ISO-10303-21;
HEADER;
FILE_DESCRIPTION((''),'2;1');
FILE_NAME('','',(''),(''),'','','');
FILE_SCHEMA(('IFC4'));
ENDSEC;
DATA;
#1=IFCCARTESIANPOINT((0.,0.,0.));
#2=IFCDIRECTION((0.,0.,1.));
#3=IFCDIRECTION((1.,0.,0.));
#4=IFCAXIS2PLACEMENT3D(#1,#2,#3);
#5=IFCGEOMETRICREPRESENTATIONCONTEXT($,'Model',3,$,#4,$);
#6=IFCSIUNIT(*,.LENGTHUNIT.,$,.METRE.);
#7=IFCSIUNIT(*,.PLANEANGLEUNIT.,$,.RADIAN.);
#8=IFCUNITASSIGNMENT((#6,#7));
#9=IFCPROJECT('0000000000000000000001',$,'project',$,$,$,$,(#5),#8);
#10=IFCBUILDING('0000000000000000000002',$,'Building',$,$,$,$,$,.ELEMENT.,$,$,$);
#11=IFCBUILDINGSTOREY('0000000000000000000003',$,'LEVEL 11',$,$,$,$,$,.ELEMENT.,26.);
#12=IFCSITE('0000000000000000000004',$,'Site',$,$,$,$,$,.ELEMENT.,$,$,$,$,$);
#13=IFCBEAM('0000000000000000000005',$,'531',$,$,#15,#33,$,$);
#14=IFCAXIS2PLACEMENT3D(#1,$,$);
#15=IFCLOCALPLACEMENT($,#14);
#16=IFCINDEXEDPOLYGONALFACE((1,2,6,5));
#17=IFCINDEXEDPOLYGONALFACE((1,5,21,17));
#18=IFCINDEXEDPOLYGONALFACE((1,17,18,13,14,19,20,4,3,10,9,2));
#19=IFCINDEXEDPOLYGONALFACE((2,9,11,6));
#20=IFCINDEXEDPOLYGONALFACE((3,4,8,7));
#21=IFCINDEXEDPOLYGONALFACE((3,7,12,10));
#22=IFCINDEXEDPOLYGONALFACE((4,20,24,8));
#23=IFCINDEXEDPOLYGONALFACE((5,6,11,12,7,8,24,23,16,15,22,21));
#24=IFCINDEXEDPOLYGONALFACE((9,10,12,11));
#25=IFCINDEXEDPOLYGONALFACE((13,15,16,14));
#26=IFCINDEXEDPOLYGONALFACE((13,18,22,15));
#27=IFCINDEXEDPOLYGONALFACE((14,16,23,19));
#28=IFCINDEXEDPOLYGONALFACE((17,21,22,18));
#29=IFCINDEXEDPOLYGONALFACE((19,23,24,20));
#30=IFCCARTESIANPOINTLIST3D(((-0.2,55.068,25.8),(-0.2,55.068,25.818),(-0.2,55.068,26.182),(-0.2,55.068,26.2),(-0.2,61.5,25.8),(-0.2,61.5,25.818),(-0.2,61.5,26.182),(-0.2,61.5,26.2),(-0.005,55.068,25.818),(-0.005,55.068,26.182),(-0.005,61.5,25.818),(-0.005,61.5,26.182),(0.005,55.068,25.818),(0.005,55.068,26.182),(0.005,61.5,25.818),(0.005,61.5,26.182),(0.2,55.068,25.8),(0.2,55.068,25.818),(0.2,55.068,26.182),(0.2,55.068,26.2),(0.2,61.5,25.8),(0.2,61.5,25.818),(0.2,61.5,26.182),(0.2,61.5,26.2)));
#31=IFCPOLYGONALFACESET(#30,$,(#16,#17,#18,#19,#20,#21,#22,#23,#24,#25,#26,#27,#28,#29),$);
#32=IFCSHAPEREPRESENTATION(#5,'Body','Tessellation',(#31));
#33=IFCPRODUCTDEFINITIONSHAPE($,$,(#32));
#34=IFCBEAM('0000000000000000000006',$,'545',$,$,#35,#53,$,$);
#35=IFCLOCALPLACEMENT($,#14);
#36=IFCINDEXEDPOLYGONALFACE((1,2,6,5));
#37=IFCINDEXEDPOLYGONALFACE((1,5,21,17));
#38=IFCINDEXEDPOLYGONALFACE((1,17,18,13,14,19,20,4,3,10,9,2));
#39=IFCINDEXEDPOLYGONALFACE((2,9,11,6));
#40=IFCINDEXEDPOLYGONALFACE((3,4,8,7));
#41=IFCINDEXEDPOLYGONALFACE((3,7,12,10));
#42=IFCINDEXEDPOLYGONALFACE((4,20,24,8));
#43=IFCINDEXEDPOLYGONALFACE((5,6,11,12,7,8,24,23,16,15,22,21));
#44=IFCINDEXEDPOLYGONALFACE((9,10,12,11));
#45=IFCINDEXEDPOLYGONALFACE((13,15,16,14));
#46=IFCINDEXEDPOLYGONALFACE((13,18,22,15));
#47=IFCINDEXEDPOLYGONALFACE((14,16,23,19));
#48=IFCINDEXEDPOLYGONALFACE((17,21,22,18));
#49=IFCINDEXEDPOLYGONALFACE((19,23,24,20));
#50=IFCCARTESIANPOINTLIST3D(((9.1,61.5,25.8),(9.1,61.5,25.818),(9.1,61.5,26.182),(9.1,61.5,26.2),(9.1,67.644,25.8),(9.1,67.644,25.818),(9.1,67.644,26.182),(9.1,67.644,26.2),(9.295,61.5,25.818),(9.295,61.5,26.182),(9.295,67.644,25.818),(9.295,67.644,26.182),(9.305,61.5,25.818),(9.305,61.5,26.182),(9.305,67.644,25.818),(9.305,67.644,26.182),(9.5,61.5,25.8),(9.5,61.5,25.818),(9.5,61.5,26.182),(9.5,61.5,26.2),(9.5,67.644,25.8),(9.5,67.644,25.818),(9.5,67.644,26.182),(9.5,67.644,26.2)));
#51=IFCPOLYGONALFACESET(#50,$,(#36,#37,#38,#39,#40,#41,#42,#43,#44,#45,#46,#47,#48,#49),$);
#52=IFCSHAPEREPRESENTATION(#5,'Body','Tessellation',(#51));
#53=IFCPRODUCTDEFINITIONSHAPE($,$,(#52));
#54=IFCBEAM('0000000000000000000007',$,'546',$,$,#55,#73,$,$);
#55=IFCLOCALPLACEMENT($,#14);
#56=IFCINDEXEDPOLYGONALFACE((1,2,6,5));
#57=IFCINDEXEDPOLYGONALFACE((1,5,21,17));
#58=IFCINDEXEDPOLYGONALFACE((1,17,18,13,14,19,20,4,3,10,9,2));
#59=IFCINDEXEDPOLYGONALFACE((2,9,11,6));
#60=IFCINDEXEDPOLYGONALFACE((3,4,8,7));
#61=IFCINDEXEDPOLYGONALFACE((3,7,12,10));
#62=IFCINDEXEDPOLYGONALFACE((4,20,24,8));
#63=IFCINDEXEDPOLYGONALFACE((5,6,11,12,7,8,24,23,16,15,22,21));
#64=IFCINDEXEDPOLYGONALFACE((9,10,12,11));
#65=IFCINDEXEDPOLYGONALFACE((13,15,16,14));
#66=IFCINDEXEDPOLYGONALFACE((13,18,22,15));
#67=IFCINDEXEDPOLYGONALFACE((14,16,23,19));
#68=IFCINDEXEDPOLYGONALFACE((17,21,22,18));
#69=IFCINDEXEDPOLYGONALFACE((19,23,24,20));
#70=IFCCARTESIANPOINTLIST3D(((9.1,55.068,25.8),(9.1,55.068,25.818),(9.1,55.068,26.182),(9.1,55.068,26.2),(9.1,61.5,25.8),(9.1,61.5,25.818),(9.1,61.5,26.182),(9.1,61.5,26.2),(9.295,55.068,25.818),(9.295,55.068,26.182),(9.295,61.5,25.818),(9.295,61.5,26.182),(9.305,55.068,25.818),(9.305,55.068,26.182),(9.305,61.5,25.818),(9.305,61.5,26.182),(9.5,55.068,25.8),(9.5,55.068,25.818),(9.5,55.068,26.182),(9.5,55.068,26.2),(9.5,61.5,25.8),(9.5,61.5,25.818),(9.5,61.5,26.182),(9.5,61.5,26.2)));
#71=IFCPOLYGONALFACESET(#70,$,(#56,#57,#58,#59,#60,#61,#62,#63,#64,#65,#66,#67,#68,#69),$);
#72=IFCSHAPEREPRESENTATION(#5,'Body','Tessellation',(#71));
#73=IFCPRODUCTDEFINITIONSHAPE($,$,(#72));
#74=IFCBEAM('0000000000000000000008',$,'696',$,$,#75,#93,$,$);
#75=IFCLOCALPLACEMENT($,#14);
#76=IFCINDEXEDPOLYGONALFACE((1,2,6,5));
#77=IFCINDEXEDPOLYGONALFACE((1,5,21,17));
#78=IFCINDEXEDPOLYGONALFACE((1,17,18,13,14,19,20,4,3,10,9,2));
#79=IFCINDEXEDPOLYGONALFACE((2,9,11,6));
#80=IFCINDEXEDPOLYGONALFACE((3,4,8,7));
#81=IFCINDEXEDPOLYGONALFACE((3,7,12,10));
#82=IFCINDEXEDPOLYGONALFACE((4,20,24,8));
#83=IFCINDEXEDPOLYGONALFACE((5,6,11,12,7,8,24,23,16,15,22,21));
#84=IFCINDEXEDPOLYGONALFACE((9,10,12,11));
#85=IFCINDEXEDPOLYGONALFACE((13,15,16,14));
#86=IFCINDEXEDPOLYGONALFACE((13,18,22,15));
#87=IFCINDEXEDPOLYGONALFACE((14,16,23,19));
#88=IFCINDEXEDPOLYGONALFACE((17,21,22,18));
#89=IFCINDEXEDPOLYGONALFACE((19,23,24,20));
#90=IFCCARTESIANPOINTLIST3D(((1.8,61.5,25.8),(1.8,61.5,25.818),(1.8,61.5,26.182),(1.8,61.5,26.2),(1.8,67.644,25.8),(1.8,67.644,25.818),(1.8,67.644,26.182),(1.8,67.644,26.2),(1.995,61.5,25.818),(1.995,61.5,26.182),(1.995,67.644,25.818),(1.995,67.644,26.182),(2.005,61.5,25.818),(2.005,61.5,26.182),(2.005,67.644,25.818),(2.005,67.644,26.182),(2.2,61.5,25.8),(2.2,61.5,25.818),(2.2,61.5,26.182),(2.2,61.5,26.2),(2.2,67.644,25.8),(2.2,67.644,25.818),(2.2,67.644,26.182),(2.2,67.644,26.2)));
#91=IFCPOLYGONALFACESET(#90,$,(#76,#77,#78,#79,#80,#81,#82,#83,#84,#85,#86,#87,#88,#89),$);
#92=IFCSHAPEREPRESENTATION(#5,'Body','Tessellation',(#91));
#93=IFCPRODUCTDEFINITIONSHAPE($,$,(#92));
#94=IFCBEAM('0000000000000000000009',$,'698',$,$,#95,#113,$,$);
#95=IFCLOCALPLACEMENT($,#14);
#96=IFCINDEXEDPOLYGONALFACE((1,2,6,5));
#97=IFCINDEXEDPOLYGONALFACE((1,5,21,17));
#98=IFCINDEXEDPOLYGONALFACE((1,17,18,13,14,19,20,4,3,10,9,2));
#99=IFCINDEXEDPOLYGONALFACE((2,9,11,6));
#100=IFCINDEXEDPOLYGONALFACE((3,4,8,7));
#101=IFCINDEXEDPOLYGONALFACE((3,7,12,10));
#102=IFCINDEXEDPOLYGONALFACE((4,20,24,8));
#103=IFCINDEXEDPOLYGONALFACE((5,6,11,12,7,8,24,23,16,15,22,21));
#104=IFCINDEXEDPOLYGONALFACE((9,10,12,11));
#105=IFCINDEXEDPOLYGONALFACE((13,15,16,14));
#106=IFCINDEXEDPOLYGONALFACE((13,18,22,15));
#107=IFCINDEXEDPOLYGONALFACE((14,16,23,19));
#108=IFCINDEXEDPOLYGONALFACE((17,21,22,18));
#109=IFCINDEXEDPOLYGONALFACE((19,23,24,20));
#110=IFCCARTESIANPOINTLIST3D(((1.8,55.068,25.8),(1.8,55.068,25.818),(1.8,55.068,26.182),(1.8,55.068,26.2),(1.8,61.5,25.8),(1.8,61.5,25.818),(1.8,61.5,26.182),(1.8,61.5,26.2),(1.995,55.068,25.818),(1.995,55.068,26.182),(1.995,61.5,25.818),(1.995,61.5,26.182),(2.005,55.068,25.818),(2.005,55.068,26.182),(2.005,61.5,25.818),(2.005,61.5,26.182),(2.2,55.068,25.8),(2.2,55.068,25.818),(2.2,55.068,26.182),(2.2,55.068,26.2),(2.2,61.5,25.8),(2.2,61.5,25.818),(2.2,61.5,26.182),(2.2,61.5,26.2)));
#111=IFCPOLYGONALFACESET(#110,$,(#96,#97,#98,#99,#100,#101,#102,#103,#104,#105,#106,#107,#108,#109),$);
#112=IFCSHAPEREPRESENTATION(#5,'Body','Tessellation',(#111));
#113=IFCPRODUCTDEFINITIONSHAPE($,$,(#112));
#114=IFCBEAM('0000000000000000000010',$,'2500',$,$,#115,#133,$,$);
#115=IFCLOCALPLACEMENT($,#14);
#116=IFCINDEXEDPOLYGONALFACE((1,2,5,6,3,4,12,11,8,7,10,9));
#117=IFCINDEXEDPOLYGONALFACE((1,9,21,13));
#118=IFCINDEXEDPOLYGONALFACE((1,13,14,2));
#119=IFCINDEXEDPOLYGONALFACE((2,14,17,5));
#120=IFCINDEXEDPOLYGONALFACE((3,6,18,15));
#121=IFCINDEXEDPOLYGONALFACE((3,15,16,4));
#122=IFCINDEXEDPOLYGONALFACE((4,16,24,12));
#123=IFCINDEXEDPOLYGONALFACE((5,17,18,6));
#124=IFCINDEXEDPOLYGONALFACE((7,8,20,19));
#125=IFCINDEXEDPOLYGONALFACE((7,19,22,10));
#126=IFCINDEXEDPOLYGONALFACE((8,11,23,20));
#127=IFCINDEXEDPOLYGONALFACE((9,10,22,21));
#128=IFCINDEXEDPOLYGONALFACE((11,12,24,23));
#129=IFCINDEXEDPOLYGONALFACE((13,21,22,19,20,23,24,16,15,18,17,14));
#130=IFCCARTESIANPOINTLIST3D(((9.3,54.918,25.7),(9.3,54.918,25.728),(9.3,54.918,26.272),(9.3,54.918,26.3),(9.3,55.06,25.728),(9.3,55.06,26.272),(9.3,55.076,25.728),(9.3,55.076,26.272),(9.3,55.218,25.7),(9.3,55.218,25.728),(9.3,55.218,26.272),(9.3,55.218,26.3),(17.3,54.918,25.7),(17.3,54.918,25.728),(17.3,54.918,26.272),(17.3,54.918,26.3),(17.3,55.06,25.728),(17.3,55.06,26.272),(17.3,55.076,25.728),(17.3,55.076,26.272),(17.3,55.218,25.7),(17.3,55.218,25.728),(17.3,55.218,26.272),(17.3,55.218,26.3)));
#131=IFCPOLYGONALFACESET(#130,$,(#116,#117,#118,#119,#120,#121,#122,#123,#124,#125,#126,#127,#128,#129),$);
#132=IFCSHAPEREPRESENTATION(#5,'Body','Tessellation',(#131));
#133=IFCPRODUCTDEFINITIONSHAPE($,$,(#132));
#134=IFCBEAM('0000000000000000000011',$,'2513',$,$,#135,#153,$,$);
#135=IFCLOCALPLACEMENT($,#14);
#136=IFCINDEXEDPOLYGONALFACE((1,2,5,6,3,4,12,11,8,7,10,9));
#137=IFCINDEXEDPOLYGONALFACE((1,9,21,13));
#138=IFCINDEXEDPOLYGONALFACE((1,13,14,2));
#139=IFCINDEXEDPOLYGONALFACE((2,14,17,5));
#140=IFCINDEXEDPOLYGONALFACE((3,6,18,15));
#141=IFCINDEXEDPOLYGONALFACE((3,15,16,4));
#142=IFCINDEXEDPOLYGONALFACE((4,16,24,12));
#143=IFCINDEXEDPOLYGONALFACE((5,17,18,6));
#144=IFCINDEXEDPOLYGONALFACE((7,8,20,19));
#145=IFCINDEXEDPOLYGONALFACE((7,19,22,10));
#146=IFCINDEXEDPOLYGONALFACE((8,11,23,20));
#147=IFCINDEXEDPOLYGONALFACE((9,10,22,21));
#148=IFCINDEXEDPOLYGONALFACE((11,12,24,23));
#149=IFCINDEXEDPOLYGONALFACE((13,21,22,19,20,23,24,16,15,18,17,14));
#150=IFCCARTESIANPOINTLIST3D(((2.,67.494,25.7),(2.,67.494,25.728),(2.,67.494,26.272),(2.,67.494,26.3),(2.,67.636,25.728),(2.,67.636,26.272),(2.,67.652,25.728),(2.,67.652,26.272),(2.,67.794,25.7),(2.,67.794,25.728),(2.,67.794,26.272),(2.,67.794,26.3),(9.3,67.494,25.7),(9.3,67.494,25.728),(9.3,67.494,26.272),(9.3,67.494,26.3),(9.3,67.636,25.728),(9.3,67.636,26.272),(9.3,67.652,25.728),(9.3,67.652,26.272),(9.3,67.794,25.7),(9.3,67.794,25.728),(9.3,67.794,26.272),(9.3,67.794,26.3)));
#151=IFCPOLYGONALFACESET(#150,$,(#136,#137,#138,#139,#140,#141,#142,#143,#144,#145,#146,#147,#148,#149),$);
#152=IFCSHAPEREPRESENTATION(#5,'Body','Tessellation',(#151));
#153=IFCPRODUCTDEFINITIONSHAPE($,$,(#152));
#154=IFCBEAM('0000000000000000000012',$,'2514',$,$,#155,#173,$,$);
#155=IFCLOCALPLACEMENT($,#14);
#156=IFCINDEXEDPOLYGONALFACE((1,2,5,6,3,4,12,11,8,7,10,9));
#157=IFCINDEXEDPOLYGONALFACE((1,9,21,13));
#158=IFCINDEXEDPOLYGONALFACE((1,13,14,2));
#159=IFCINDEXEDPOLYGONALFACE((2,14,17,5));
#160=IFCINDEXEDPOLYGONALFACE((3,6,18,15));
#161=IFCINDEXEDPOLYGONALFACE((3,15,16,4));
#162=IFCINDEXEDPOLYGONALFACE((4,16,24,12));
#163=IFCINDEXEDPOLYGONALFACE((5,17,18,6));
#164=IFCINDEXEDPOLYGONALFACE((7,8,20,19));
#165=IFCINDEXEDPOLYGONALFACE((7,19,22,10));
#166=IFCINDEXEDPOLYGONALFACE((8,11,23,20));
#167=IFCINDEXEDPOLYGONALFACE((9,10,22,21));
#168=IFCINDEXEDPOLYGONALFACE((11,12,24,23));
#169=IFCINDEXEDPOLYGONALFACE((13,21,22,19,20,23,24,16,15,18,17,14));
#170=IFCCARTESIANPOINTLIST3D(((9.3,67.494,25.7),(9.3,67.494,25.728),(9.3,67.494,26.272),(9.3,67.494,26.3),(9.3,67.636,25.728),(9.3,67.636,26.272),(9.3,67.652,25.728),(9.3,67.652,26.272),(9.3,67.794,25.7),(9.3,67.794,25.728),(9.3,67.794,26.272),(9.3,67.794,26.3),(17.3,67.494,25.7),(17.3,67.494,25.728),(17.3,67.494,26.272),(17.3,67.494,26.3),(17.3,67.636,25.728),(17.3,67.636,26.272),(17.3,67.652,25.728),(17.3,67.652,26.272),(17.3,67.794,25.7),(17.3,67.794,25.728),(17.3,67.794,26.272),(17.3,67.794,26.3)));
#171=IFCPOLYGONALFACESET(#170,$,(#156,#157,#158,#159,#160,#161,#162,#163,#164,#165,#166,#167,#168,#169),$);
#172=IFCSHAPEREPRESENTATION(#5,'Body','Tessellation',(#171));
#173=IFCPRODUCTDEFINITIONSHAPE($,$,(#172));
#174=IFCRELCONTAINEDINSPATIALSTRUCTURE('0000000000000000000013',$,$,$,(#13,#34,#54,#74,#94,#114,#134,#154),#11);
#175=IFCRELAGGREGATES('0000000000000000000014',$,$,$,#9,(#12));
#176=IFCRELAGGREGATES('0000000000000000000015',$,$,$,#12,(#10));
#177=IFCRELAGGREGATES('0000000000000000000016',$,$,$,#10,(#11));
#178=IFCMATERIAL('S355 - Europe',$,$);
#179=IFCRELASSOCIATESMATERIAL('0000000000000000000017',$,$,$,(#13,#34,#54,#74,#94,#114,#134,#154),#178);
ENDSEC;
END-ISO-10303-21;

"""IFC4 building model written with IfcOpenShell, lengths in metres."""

from ifc_helpers import new_model, si_unit, frame, origin_with_axes, origin_2d_with_axis, place, context, project, spatial, i_section, extrude, material, material_profile, profile_set, profile_usage, element, save


model = new_model("IFC4")

# Units and contexts
model_context = context("Model", 3, world=origin_with_axes())
ifc_project = project(units=[si_unit("LENGTHUNIT", "METRE"), si_unit("PLANEANGLEUNIT", "RADIAN")], contexts=[model_context])

# Site, building, storey
site = spatial("IfcSite", under=ifc_project, Name="Site", CompositionType="ELEMENT")
building = spatial("IfcBuilding", under=site, Name="Building", CompositionType="ELEMENT")
storey = spatial("IfcBuildingStorey", under=building, Name="LEVEL 11", CompositionType="ELEMENT", Elevation=26.0)

# Shared definitions
ifc_material = material(Name="S355 - Europe")

# Beams
ifc_material_profile_1 = material_profile(ifc_material, i_section(OverallWidth=0.4, OverallDepth=0.4, WebThickness=0.01, FlangeThickness=0.018, at=origin_2d_with_axis()))
ifc_profile_set_1 = profile_set([ifc_material_profile_1])
ifc_profile_usage_1 = profile_usage(ifc_profile_set_1, cardinal=10)
beam_1_placement = place(None, frame((0.0, 61.5, 26.0), z_axis=(0.0, -1.0, 0.0), x_axis=(1.0, 0.0, 0.0)))
element("IfcBeam", 1, at=beam_1_placement, inside=storey, material=ifc_profile_usage_1, Name="531", context=model_context, shape_type="SweptSolid", body=[
    extrude(i_section(OverallWidth=0.4, OverallDepth=0.4, WebThickness=0.01, FlangeThickness=0.018, at=origin_2d_with_axis()), origin_with_axes(), (0.0, 0.0, 1.0), 6.432),
])
ifc_material_profile_2 = material_profile(ifc_material, i_section(OverallWidth=0.4, OverallDepth=0.4, WebThickness=0.01, FlangeThickness=0.018, at=origin_2d_with_axis()))
ifc_profile_set_2 = profile_set([ifc_material_profile_2])
ifc_profile_usage_2 = profile_usage(ifc_profile_set_2, cardinal=10)
beam_2_placement = place(None, frame((9.3, 67.644, 26.0), z_axis=(0.0, -1.0, 0.0), x_axis=(1.0, 0.0, 0.0)))
element("IfcBeam", 2, at=beam_2_placement, inside=storey, material=ifc_profile_usage_2, Name="545", context=model_context, shape_type="SweptSolid", body=[
    extrude(i_section(OverallWidth=0.4, OverallDepth=0.4, WebThickness=0.01, FlangeThickness=0.018, at=origin_2d_with_axis()), origin_with_axes(), (0.0, 0.0, 1.0), 6.144),
])
ifc_material_profile_3 = material_profile(ifc_material, i_section(OverallWidth=0.4, OverallDepth=0.4, WebThickness=0.01, FlangeThickness=0.018, at=origin_2d_with_axis()))
ifc_profile_set_3 = profile_set([ifc_material_profile_3])
ifc_profile_usage_3 = profile_usage(ifc_profile_set_3, cardinal=10)
beam_3_placement = place(None, frame((9.3, 61.5, 26.0), z_axis=(0.0, -1.0, 0.0), x_axis=(1.0, 0.0, 0.0)))
element("IfcBeam", 3, at=beam_3_placement, inside=storey, material=ifc_profile_usage_3, Name="546", context=model_context, shape_type="SweptSolid", body=[
    extrude(i_section(OverallWidth=0.4, OverallDepth=0.4, WebThickness=0.01, FlangeThickness=0.018, at=origin_2d_with_axis()), origin_with_axes(), (0.0, 0.0, 1.0), 6.432),
])
ifc_material_profile_4 = material_profile(ifc_material, i_section(OverallWidth=0.4, OverallDepth=0.4, WebThickness=0.01, FlangeThickness=0.018, at=origin_2d_with_axis()))
ifc_profile_set_4 = profile_set([ifc_material_profile_4])
ifc_profile_usage_4 = profile_usage(ifc_profile_set_4, cardinal=10)
beam_4_placement = place(None, frame((2.0, 67.644, 26.0), z_axis=(0.0, -1.0, 0.0), x_axis=(1.0, 0.0, 0.0)))
element("IfcBeam", 4, at=beam_4_placement, inside=storey, material=ifc_profile_usage_4, Name="696", context=model_context, shape_type="SweptSolid", body=[
    extrude(i_section(OverallWidth=0.4, OverallDepth=0.4, WebThickness=0.01, FlangeThickness=0.018, at=origin_2d_with_axis()), origin_with_axes(), (0.0, 0.0, 1.0), 6.144),
])
ifc_material_profile_5 = material_profile(ifc_material, i_section(OverallWidth=0.4, OverallDepth=0.4, WebThickness=0.01, FlangeThickness=0.018, at=origin_2d_with_axis()))
ifc_profile_set_5 = profile_set([ifc_material_profile_5])
ifc_profile_usage_5 = profile_usage(ifc_profile_set_5, cardinal=10)
beam_5_placement = place(None, frame((2.0, 61.5, 26.0), z_axis=(0.0, -1.0, 0.0), x_axis=(1.0, 0.0, 0.0)))
element("IfcBeam", 5, at=beam_5_placement, inside=storey, material=ifc_profile_usage_5, Name="698", context=model_context, shape_type="SweptSolid", body=[
    extrude(i_section(OverallWidth=0.4, OverallDepth=0.4, WebThickness=0.01, FlangeThickness=0.018, at=origin_2d_with_axis()), origin_with_axes(), (0.0, 0.0, 1.0), 6.432),
])
ifc_material_profile_6 = material_profile(ifc_material, i_section(OverallWidth=0.3, OverallDepth=0.6, WebThickness=0.016, FlangeThickness=0.028, at=origin_2d_with_axis()))
ifc_profile_set_6 = profile_set([ifc_material_profile_6])
ifc_profile_usage_6 = profile_usage(ifc_profile_set_6, cardinal=10)
beam_6_placement = place(None, frame((9.3, 55.068, 26.0), z_axis=(1.0, 0.0, 0.0), x_axis=(0.0, 1.0, 0.0)))
element("IfcBeam", 6, at=beam_6_placement, inside=storey, material=ifc_profile_usage_6, Name="2500", context=model_context, shape_type="SweptSolid", body=[
    extrude(i_section(OverallWidth=0.3, OverallDepth=0.6, WebThickness=0.016, FlangeThickness=0.028, at=origin_2d_with_axis()), origin_with_axes(), (0.0, 0.0, 1.0), 8.0),
])
ifc_material_profile_7 = material_profile(ifc_material, i_section(OverallWidth=0.3, OverallDepth=0.6, WebThickness=0.016, FlangeThickness=0.028, at=origin_2d_with_axis()))
ifc_profile_set_7 = profile_set([ifc_material_profile_7])
ifc_profile_usage_7 = profile_usage(ifc_profile_set_7, cardinal=10)
beam_7_placement = place(None, frame((2.0, 67.644, 26.0), z_axis=(1.0, 0.0, 0.0), x_axis=(0.0, 1.0, 0.0)))
element("IfcBeam", 7, at=beam_7_placement, inside=storey, material=ifc_profile_usage_7, Name="2513", context=model_context, shape_type="SweptSolid", body=[
    extrude(i_section(OverallWidth=0.3, OverallDepth=0.6, WebThickness=0.016, FlangeThickness=0.028, at=origin_2d_with_axis()), origin_with_axes(), (0.0, 0.0, 1.0), 7.3),
])
ifc_material_profile_8 = material_profile(ifc_material, i_section(OverallWidth=0.3, OverallDepth=0.6, WebThickness=0.016, FlangeThickness=0.028, at=origin_2d_with_axis()))
ifc_profile_set_8 = profile_set([ifc_material_profile_8])
ifc_profile_usage_8 = profile_usage(ifc_profile_set_8, cardinal=10)
beam_8_placement = place(None, frame((9.3, 67.644, 26.0), z_axis=(1.0, 0.0, 0.0), x_axis=(0.0, 1.0, 0.0)))
element("IfcBeam", 8, at=beam_8_placement, inside=storey, material=ifc_profile_usage_8, Name="2514", context=model_context, shape_type="SweptSolid", body=[
    extrude(i_section(OverallWidth=0.3, OverallDepth=0.6, WebThickness=0.016, FlangeThickness=0.028, at=origin_2d_with_axis()), origin_with_axes(), (0.0, 0.0, 1.0), 8.0),
])

save(model, "model.ifc")
